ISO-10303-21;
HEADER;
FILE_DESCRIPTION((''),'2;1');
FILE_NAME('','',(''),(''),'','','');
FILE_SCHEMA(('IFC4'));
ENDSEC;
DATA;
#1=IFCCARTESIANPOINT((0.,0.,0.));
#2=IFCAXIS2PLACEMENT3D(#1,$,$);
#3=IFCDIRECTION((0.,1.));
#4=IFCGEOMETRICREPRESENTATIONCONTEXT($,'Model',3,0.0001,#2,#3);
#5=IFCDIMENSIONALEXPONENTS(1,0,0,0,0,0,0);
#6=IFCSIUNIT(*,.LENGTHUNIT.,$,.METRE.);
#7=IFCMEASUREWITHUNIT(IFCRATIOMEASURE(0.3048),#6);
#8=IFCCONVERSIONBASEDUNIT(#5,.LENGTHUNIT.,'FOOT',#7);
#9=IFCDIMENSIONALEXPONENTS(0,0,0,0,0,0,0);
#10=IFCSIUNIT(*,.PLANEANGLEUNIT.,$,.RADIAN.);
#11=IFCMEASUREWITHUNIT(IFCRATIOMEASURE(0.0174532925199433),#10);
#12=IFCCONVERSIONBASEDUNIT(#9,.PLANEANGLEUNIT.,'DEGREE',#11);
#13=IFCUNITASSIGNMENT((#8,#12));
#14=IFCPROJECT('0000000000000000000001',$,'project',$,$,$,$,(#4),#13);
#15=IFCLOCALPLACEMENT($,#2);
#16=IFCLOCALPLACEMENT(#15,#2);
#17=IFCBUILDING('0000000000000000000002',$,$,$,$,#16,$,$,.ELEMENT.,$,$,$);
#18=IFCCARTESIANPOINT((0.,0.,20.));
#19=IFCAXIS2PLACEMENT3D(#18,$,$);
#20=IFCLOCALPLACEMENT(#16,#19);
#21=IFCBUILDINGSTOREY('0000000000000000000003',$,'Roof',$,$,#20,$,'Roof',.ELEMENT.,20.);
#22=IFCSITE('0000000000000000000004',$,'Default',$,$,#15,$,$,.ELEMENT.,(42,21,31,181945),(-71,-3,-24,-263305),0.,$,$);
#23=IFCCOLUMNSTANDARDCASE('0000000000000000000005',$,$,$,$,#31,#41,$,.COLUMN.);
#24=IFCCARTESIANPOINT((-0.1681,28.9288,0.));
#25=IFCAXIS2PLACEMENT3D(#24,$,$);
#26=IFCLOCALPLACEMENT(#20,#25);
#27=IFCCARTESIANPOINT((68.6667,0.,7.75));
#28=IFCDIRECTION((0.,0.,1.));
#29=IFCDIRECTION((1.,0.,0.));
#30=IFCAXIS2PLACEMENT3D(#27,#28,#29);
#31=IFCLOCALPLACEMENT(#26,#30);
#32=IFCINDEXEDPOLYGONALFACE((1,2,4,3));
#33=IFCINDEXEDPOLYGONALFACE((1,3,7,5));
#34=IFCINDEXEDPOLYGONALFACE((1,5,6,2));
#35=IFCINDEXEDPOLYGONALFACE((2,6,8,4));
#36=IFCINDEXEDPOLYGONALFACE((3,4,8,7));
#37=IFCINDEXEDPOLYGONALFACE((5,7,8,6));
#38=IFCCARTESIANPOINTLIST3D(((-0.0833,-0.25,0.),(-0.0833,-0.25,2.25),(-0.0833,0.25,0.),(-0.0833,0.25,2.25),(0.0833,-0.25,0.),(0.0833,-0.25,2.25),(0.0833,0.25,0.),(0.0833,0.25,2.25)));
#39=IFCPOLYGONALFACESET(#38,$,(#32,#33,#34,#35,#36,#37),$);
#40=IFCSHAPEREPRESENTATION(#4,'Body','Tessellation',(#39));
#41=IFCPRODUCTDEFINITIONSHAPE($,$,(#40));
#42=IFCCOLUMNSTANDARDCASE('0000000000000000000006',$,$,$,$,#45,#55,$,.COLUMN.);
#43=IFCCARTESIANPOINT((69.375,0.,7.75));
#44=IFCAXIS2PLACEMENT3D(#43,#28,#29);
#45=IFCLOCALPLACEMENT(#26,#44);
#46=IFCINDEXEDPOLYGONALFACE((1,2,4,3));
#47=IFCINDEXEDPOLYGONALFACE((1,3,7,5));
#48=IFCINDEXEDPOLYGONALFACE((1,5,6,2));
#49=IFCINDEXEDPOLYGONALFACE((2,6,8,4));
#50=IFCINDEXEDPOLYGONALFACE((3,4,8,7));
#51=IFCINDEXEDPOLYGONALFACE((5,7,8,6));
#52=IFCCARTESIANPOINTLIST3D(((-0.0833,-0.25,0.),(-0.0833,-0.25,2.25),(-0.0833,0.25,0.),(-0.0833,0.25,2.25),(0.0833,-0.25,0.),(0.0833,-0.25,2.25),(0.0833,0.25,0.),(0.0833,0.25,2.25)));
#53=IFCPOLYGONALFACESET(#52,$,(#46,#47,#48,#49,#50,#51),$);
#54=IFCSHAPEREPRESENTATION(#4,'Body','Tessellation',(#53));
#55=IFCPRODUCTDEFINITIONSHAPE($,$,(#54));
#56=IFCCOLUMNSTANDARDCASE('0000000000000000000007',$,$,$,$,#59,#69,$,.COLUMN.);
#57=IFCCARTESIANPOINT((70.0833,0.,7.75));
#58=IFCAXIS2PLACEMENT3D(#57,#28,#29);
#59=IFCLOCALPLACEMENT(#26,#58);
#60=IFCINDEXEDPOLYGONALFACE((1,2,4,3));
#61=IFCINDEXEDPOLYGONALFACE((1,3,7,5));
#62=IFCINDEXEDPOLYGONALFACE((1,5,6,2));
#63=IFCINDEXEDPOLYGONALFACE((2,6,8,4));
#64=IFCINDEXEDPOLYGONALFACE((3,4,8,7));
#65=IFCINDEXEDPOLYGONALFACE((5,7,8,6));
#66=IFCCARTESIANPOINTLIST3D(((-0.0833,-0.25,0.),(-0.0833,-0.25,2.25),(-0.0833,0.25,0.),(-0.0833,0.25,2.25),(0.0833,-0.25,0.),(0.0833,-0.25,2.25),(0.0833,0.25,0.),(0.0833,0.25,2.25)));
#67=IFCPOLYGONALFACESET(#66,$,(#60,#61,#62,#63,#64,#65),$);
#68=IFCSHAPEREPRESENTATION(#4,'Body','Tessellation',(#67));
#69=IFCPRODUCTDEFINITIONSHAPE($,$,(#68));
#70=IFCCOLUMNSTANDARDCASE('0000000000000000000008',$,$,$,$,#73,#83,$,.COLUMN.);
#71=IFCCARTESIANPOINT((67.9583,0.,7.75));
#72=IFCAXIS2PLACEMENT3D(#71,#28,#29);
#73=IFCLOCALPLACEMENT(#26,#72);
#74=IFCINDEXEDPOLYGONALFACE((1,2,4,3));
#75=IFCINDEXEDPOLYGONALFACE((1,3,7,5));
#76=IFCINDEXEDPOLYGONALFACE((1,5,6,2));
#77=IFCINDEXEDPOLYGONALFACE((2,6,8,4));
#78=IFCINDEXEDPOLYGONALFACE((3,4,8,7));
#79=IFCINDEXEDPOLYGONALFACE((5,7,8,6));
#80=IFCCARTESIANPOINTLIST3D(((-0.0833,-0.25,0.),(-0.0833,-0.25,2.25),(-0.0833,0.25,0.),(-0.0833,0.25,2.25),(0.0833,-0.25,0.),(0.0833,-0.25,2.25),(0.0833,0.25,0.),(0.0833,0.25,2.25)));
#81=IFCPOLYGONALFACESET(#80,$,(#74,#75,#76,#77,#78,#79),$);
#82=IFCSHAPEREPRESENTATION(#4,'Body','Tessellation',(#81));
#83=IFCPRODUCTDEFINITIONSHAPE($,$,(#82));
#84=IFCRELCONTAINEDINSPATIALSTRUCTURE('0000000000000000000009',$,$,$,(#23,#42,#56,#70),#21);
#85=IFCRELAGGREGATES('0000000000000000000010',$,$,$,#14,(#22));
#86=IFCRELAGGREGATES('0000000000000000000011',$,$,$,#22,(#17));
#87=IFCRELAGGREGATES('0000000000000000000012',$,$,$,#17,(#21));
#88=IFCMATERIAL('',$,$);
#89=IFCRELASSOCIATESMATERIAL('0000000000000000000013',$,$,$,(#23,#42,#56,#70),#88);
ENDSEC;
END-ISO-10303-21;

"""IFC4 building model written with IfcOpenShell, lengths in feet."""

from ifc_helpers import new_model, entity, si_unit, converted_unit, direction, frame, origin, place, context, project, spatial, rectangle, extrude, material, element, save


model = new_model("IFC4")

# Units and contexts
model_context = context("Model", 3, precision=0.0001, world=origin(), true_north=direction((0.0, 1.0)))
ifc_project = project(units=[converted_unit("LENGTHUNIT", "FOOT", entity("IfcRatioMeasure", 0.3048), si_unit("LENGTHUNIT", "METRE"), dimensions=[1, 0, 0, 0, 0, 0, 0]), converted_unit("PLANEANGLEUNIT", "DEGREE", entity("IfcRatioMeasure", 0.0174532925199433), si_unit("PLANEANGLEUNIT", "RADIAN"), dimensions=[0, 0, 0, 0, 0, 0, 0])], contexts=[model_context])

# Site, building, storey
site_placement = place(None, origin())
site = spatial("IfcSite", under=ifc_project, at=site_placement, Name="Default", CompositionType="ELEMENT", RefLatitude=(42, 21, 31, 181945), RefLongitude=(-71, -3, -24, -263305), RefElevation=0.0)
building_placement = place(site_placement, origin())
building = spatial("IfcBuilding", under=site, at=building_placement, CompositionType="ELEMENT")
storey_placement = place(building_placement, frame((0.0, 0.0, 20.0)))
storey = spatial("IfcBuildingStorey", under=building, at=storey_placement, Name="Roof", LongName="Roof", CompositionType="ELEMENT", Elevation=20.0)

# Columns
ifc_material_1 = material(Name="")
placement = place(storey_placement, frame((-0.1681, 28.9288, 0.0)))
for number, where, z_axis, x_axis in (
    (1, (68.6667, 0.0, 7.75), (0.0, 0.0, 1.0), (1.0, 0.0, 0.0)),
    (2, (69.375, 0.0, 7.75), (0.0, 0.0, 1.0), (1.0, 0.0, 0.0)),
    (3, (70.0833, 0.0, 7.75), (0.0, 0.0, 1.0), (1.0, 0.0, 0.0)),
    (4, (67.9583, 0.0, 7.75), (0.0, 0.0, 1.0), (1.0, 0.0, 0.0)),
):
    element("IfcColumnStandardCase", number, at=place(placement, frame(where, z_axis=z_axis, x_axis=x_axis)), inside=storey, material=ifc_material_1, PredefinedType="COLUMN", context=model_context, shape_type="SweptSolid", body=[
        extrude(rectangle(XDim=0.1667, YDim=0.5), origin(), (0.0, 0.0, 1.0), 2.25),
    ])

save(model, "model.ifc")
